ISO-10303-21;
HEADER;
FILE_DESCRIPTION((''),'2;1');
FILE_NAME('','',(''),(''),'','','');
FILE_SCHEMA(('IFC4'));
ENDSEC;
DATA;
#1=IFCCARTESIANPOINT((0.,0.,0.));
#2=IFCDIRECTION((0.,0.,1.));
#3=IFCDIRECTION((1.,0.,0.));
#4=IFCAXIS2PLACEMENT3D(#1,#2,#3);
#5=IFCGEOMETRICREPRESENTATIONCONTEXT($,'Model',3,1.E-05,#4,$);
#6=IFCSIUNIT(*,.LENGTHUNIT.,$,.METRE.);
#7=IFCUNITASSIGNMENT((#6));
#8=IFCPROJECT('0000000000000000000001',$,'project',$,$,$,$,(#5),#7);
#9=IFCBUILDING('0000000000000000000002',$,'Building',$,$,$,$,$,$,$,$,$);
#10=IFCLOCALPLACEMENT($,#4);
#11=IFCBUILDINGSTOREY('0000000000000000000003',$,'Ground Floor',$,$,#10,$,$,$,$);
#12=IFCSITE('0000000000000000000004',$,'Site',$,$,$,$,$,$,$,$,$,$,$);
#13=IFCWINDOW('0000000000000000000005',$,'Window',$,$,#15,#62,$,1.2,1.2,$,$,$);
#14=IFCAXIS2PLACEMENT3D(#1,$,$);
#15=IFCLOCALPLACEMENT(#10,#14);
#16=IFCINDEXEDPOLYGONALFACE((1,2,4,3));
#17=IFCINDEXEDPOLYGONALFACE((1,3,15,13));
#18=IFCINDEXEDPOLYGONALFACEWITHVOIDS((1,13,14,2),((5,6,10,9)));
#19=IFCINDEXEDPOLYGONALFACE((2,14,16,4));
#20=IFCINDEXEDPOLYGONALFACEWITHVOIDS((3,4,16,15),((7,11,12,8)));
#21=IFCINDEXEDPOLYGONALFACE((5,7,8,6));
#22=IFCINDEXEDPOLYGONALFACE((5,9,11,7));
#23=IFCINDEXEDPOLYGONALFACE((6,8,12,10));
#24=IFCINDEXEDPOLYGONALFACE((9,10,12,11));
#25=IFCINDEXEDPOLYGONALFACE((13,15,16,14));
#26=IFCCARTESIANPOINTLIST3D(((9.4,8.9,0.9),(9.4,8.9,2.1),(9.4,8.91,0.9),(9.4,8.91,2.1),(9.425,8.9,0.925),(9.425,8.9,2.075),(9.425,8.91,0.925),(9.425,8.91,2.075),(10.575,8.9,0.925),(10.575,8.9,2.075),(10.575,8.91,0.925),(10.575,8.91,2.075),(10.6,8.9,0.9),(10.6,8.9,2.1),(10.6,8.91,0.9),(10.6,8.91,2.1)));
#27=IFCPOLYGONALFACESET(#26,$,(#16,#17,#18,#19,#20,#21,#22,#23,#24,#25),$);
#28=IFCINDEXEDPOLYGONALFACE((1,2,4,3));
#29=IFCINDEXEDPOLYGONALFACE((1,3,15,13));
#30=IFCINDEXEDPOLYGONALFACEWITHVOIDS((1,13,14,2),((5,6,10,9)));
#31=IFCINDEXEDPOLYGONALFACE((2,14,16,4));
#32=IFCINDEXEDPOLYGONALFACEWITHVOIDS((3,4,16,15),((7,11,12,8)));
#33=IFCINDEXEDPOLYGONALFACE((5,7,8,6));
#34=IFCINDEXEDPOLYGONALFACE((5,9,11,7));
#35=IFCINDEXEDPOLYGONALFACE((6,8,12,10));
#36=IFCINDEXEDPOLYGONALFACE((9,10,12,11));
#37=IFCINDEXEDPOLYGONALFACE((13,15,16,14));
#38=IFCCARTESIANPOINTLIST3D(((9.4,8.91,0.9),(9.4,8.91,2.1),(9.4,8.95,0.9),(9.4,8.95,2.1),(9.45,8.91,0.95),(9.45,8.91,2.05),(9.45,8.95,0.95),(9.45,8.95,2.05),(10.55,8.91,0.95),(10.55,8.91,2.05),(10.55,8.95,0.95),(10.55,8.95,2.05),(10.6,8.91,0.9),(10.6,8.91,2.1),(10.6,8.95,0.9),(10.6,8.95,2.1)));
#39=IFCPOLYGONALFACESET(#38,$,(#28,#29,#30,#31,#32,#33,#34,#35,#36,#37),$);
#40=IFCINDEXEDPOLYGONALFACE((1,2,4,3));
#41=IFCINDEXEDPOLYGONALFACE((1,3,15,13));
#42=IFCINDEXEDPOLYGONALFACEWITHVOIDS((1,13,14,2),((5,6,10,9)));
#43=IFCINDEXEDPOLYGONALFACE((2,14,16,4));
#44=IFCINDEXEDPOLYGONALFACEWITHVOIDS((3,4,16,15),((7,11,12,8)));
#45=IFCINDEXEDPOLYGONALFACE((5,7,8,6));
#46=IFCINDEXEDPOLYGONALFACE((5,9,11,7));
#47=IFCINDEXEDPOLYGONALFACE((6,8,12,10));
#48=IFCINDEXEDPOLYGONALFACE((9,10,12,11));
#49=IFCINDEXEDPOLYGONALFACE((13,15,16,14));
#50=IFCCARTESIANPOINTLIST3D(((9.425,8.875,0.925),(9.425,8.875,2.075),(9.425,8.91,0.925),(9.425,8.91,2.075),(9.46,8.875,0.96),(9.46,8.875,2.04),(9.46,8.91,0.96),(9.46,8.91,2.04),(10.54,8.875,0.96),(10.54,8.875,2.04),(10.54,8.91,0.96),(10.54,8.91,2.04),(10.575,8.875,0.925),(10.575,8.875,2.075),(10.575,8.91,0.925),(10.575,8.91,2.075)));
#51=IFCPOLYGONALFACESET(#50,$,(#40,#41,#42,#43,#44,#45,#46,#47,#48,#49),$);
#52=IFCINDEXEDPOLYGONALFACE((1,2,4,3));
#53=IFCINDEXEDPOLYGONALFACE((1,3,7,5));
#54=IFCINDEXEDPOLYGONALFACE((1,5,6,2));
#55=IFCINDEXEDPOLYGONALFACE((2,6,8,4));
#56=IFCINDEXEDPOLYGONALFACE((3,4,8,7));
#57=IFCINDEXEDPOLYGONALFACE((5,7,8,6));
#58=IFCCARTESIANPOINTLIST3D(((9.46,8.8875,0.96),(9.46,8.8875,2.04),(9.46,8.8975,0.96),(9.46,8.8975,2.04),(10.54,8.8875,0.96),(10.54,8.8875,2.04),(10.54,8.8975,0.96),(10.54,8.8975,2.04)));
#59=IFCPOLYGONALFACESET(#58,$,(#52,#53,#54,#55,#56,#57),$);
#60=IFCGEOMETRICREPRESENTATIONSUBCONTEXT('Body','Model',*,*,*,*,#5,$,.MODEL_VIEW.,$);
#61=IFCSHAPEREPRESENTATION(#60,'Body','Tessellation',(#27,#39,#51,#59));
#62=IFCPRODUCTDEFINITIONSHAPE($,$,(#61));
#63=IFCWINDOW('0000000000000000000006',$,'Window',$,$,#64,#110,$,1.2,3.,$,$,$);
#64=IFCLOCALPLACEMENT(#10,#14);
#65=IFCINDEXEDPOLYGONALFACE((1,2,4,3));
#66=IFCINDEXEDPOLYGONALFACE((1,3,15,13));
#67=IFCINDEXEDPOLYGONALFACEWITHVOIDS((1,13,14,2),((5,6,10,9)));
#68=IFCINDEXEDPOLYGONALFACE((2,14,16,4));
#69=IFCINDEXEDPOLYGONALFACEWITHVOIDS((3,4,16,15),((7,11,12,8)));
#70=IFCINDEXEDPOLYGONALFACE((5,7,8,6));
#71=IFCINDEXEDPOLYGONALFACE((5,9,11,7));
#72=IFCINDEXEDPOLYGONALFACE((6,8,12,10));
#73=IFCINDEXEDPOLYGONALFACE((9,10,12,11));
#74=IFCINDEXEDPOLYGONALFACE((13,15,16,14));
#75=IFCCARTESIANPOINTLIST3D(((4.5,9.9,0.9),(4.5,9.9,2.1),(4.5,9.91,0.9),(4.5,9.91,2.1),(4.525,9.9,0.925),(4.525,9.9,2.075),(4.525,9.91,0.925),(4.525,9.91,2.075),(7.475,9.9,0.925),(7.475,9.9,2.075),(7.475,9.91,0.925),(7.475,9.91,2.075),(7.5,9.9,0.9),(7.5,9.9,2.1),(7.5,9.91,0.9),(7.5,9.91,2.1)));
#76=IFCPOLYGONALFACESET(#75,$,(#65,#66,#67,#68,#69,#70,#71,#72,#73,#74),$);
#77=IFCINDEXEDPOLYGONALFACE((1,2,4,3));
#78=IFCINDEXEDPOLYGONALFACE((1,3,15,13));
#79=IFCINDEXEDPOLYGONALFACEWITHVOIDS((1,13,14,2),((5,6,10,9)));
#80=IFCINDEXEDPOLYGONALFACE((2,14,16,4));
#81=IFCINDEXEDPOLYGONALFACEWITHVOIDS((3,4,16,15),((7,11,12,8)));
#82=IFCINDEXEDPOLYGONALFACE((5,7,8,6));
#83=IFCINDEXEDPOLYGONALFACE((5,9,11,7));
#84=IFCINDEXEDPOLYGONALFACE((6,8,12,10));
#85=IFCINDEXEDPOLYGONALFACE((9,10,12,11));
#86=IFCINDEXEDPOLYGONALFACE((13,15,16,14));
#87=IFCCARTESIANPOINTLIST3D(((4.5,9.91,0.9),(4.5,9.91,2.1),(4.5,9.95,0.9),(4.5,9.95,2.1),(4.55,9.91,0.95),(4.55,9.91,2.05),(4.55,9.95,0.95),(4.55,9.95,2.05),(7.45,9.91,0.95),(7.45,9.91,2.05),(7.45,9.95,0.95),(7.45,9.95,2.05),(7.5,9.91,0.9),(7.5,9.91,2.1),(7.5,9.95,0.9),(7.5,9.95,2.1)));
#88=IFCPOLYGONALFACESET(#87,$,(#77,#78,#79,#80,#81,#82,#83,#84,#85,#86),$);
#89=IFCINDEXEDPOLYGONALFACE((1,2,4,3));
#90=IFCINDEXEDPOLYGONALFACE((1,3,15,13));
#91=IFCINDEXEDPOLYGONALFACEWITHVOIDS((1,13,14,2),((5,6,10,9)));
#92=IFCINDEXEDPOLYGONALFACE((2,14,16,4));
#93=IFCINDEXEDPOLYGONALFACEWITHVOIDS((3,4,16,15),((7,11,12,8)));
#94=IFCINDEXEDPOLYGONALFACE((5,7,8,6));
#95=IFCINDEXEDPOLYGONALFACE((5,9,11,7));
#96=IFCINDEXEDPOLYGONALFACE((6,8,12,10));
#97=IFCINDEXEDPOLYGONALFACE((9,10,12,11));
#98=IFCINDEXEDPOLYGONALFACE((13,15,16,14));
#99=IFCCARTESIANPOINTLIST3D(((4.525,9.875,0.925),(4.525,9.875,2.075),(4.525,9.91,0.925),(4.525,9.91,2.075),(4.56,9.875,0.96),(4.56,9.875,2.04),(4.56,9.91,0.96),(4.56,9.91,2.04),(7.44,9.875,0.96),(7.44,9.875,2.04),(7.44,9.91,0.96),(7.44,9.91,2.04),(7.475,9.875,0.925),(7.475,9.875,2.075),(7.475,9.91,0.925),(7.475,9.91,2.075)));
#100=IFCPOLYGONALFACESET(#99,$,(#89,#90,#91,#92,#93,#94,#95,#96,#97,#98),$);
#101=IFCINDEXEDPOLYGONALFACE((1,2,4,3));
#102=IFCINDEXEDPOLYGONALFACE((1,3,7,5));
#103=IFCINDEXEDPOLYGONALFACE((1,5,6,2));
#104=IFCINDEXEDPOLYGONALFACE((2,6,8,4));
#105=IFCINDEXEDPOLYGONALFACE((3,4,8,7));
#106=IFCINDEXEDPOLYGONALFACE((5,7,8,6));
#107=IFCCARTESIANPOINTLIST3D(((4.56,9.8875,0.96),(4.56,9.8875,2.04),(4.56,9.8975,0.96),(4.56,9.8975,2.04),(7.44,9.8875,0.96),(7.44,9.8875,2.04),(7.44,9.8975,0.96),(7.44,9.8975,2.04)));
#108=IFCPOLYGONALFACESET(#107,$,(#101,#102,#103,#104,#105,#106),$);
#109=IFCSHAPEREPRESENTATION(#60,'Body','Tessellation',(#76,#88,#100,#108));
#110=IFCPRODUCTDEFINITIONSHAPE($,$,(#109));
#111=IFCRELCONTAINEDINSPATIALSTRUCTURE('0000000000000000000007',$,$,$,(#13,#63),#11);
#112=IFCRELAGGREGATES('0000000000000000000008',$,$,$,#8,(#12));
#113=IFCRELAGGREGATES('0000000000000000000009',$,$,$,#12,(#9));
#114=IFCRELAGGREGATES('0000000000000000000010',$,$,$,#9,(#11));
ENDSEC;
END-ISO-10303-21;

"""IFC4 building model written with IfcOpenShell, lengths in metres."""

from ifc_helpers import new_model, si_unit, frame, origin_with_axes, place, context, subcontext, project, spatial, line, indexed_curve, outline, extrude, element, save


model = new_model("IFC4")

# Units and contexts
model_context = context("Model", 3, precision=1e-05, world=origin_with_axes())
body_context = subcontext(model_context, "Body", "Model", "MODEL_VIEW")
ifc_project = project(units=[si_unit("LENGTHUNIT", "METRE")], contexts=[model_context])

# Site, building, storey
site = spatial("IfcSite", under=ifc_project, Name="Site")
building = spatial("IfcBuilding", under=site, Name="Building")
storey_placement = place(None, origin_with_axes())
storey = spatial("IfcBuildingStorey", under=building, at=storey_placement, Name="Ground Floor")

# Windows
window_1_placement = place(storey_placement, frame((10.6, 9.0, 0.9), z_axis=(0.0, 0.0, 1.0), x_axis=(-1.0, 0.0, 0.0)))
element("IfcWindow", 1, at=window_1_placement, inside=storey, Name="Window", OverallHeight=1.2, OverallWidth=1.2, context=body_context, shape_type="SweptSolid", body=[
    extrude(outline(indexed_curve([(0.0, 0.0), (1.2, 0.0), (1.2, 1.2), (0.0, 1.2)], segments=[line(1, 2, 3, 4, 1)]), holes=[indexed_curve([(0.025, 0.025), (1.175, 0.025), (1.175, 1.175), (0.025, 1.175)], segments=[line(1, 2, 3, 4, 1)])]), frame((0.0, 0.09, 0.0), z_axis=(0.0, -1.0, 0.0), x_axis=(1.0, 0.0, 0.0)), (0.0, 0.0, -1.0), 0.01),
    extrude(outline(indexed_curve([(0.0, 0.0), (1.2, 0.0), (1.2, 1.2), (0.0, 1.2)], segments=[line(1, 2, 3, 4, 1)]), holes=[indexed_curve([(0.05, 0.05), (1.15, 0.05), (1.15, 1.15), (0.05, 1.15)], segments=[line(1, 2, 3, 4, 1)])]), frame((0.0, 0.05, 0.0), z_axis=(0.0, -1.0, 0.0), x_axis=(1.0, 0.0, 0.0)), (0.0, 0.0, -1.0), 0.04),
    extrude(outline(indexed_curve([(0.0, 0.0), (1.15, 0.0), (1.15, 1.15), (0.0, 1.15)], segments=[line(1, 2, 3, 4, 1)]), holes=[indexed_curve([(0.035, 0.035), (1.115, 0.035), (1.115, 1.115), (0.035, 1.115)], segments=[line(1, 2, 3, 4, 1)])]), frame((0.025, 0.09, 0.025), z_axis=(0.0, -1.0, 0.0), x_axis=(1.0, 0.0, 0.0)), (0.0, 0.0, -1.0), 0.035),
    extrude(outline(indexed_curve([(0.035, 0.035), (1.115, 0.035), (1.115, 1.115), (0.035, 1.115)], segments=[line(1, 2, 3, 4, 1)])), frame((0.025, 0.1025, 0.025), z_axis=(0.0, -1.0, 0.0), x_axis=(1.0, 0.0, 0.0)), (0.0, 0.0, -1.0), 0.01),
])
window_2_placement = place(storey_placement, frame((7.5, 10.0, 0.9), z_axis=(0.0, 0.0, 1.0), x_axis=(-1.0, 0.0, 0.0)))
element("IfcWindow", 2, at=window_2_placement, inside=storey, Name="Window", OverallHeight=1.2, OverallWidth=3.0, context=body_context, shape_type="SweptSolid", body=[
    extrude(outline(indexed_curve([(0.0, 0.0), (3.0, 0.0), (3.0, 1.2), (0.0, 1.2)], segments=[line(1, 2, 3, 4, 1)]), holes=[indexed_curve([(0.025, 0.025), (2.975, 0.025), (2.975, 1.175), (0.025, 1.175)], segments=[line(1, 2, 3, 4, 1)])]), frame((0.0, 0.09, 0.0), z_axis=(0.0, -1.0, 0.0), x_axis=(1.0, 0.0, 0.0)), (0.0, 0.0, -1.0), 0.01),
    extrude(outline(indexed_curve([(0.0, 0.0), (3.0, 0.0), (3.0, 1.2), (0.0, 1.2)], segments=[line(1, 2, 3, 4, 1)]), holes=[indexed_curve([(0.05, 0.05), (2.95, 0.05), (2.95, 1.15), (0.05, 1.15)], segments=[line(1, 2, 3, 4, 1)])]), frame((0.0, 0.05, 0.0), z_axis=(0.0, -1.0, 0.0), x_axis=(1.0, 0.0, 0.0)), (0.0, 0.0, -1.0), 0.04),
    extrude(outline(indexed_curve([(0.0, 0.0), (2.95, 0.0), (2.95, 1.15), (0.0, 1.15)], segments=[line(1, 2, 3, 4, 1)]), holes=[indexed_curve([(0.035, 0.035), (2.915, 0.035), (2.915, 1.115), (0.035, 1.115)], segments=[line(1, 2, 3, 4, 1)])]), frame((0.025, 0.09, 0.025), z_axis=(0.0, -1.0, 0.0), x_axis=(1.0, 0.0, 0.0)), (0.0, 0.0, -1.0), 0.035),
    extrude(outline(indexed_curve([(0.035, 0.035), (2.915, 0.035), (2.915, 1.115), (0.035, 1.115)], segments=[line(1, 2, 3, 4, 1)])), frame((0.025, 0.1025, 0.025), z_axis=(0.0, -1.0, 0.0), x_axis=(1.0, 0.0, 0.0)), (0.0, 0.0, -1.0), 0.01),
])

save(model, "model.ifc")
